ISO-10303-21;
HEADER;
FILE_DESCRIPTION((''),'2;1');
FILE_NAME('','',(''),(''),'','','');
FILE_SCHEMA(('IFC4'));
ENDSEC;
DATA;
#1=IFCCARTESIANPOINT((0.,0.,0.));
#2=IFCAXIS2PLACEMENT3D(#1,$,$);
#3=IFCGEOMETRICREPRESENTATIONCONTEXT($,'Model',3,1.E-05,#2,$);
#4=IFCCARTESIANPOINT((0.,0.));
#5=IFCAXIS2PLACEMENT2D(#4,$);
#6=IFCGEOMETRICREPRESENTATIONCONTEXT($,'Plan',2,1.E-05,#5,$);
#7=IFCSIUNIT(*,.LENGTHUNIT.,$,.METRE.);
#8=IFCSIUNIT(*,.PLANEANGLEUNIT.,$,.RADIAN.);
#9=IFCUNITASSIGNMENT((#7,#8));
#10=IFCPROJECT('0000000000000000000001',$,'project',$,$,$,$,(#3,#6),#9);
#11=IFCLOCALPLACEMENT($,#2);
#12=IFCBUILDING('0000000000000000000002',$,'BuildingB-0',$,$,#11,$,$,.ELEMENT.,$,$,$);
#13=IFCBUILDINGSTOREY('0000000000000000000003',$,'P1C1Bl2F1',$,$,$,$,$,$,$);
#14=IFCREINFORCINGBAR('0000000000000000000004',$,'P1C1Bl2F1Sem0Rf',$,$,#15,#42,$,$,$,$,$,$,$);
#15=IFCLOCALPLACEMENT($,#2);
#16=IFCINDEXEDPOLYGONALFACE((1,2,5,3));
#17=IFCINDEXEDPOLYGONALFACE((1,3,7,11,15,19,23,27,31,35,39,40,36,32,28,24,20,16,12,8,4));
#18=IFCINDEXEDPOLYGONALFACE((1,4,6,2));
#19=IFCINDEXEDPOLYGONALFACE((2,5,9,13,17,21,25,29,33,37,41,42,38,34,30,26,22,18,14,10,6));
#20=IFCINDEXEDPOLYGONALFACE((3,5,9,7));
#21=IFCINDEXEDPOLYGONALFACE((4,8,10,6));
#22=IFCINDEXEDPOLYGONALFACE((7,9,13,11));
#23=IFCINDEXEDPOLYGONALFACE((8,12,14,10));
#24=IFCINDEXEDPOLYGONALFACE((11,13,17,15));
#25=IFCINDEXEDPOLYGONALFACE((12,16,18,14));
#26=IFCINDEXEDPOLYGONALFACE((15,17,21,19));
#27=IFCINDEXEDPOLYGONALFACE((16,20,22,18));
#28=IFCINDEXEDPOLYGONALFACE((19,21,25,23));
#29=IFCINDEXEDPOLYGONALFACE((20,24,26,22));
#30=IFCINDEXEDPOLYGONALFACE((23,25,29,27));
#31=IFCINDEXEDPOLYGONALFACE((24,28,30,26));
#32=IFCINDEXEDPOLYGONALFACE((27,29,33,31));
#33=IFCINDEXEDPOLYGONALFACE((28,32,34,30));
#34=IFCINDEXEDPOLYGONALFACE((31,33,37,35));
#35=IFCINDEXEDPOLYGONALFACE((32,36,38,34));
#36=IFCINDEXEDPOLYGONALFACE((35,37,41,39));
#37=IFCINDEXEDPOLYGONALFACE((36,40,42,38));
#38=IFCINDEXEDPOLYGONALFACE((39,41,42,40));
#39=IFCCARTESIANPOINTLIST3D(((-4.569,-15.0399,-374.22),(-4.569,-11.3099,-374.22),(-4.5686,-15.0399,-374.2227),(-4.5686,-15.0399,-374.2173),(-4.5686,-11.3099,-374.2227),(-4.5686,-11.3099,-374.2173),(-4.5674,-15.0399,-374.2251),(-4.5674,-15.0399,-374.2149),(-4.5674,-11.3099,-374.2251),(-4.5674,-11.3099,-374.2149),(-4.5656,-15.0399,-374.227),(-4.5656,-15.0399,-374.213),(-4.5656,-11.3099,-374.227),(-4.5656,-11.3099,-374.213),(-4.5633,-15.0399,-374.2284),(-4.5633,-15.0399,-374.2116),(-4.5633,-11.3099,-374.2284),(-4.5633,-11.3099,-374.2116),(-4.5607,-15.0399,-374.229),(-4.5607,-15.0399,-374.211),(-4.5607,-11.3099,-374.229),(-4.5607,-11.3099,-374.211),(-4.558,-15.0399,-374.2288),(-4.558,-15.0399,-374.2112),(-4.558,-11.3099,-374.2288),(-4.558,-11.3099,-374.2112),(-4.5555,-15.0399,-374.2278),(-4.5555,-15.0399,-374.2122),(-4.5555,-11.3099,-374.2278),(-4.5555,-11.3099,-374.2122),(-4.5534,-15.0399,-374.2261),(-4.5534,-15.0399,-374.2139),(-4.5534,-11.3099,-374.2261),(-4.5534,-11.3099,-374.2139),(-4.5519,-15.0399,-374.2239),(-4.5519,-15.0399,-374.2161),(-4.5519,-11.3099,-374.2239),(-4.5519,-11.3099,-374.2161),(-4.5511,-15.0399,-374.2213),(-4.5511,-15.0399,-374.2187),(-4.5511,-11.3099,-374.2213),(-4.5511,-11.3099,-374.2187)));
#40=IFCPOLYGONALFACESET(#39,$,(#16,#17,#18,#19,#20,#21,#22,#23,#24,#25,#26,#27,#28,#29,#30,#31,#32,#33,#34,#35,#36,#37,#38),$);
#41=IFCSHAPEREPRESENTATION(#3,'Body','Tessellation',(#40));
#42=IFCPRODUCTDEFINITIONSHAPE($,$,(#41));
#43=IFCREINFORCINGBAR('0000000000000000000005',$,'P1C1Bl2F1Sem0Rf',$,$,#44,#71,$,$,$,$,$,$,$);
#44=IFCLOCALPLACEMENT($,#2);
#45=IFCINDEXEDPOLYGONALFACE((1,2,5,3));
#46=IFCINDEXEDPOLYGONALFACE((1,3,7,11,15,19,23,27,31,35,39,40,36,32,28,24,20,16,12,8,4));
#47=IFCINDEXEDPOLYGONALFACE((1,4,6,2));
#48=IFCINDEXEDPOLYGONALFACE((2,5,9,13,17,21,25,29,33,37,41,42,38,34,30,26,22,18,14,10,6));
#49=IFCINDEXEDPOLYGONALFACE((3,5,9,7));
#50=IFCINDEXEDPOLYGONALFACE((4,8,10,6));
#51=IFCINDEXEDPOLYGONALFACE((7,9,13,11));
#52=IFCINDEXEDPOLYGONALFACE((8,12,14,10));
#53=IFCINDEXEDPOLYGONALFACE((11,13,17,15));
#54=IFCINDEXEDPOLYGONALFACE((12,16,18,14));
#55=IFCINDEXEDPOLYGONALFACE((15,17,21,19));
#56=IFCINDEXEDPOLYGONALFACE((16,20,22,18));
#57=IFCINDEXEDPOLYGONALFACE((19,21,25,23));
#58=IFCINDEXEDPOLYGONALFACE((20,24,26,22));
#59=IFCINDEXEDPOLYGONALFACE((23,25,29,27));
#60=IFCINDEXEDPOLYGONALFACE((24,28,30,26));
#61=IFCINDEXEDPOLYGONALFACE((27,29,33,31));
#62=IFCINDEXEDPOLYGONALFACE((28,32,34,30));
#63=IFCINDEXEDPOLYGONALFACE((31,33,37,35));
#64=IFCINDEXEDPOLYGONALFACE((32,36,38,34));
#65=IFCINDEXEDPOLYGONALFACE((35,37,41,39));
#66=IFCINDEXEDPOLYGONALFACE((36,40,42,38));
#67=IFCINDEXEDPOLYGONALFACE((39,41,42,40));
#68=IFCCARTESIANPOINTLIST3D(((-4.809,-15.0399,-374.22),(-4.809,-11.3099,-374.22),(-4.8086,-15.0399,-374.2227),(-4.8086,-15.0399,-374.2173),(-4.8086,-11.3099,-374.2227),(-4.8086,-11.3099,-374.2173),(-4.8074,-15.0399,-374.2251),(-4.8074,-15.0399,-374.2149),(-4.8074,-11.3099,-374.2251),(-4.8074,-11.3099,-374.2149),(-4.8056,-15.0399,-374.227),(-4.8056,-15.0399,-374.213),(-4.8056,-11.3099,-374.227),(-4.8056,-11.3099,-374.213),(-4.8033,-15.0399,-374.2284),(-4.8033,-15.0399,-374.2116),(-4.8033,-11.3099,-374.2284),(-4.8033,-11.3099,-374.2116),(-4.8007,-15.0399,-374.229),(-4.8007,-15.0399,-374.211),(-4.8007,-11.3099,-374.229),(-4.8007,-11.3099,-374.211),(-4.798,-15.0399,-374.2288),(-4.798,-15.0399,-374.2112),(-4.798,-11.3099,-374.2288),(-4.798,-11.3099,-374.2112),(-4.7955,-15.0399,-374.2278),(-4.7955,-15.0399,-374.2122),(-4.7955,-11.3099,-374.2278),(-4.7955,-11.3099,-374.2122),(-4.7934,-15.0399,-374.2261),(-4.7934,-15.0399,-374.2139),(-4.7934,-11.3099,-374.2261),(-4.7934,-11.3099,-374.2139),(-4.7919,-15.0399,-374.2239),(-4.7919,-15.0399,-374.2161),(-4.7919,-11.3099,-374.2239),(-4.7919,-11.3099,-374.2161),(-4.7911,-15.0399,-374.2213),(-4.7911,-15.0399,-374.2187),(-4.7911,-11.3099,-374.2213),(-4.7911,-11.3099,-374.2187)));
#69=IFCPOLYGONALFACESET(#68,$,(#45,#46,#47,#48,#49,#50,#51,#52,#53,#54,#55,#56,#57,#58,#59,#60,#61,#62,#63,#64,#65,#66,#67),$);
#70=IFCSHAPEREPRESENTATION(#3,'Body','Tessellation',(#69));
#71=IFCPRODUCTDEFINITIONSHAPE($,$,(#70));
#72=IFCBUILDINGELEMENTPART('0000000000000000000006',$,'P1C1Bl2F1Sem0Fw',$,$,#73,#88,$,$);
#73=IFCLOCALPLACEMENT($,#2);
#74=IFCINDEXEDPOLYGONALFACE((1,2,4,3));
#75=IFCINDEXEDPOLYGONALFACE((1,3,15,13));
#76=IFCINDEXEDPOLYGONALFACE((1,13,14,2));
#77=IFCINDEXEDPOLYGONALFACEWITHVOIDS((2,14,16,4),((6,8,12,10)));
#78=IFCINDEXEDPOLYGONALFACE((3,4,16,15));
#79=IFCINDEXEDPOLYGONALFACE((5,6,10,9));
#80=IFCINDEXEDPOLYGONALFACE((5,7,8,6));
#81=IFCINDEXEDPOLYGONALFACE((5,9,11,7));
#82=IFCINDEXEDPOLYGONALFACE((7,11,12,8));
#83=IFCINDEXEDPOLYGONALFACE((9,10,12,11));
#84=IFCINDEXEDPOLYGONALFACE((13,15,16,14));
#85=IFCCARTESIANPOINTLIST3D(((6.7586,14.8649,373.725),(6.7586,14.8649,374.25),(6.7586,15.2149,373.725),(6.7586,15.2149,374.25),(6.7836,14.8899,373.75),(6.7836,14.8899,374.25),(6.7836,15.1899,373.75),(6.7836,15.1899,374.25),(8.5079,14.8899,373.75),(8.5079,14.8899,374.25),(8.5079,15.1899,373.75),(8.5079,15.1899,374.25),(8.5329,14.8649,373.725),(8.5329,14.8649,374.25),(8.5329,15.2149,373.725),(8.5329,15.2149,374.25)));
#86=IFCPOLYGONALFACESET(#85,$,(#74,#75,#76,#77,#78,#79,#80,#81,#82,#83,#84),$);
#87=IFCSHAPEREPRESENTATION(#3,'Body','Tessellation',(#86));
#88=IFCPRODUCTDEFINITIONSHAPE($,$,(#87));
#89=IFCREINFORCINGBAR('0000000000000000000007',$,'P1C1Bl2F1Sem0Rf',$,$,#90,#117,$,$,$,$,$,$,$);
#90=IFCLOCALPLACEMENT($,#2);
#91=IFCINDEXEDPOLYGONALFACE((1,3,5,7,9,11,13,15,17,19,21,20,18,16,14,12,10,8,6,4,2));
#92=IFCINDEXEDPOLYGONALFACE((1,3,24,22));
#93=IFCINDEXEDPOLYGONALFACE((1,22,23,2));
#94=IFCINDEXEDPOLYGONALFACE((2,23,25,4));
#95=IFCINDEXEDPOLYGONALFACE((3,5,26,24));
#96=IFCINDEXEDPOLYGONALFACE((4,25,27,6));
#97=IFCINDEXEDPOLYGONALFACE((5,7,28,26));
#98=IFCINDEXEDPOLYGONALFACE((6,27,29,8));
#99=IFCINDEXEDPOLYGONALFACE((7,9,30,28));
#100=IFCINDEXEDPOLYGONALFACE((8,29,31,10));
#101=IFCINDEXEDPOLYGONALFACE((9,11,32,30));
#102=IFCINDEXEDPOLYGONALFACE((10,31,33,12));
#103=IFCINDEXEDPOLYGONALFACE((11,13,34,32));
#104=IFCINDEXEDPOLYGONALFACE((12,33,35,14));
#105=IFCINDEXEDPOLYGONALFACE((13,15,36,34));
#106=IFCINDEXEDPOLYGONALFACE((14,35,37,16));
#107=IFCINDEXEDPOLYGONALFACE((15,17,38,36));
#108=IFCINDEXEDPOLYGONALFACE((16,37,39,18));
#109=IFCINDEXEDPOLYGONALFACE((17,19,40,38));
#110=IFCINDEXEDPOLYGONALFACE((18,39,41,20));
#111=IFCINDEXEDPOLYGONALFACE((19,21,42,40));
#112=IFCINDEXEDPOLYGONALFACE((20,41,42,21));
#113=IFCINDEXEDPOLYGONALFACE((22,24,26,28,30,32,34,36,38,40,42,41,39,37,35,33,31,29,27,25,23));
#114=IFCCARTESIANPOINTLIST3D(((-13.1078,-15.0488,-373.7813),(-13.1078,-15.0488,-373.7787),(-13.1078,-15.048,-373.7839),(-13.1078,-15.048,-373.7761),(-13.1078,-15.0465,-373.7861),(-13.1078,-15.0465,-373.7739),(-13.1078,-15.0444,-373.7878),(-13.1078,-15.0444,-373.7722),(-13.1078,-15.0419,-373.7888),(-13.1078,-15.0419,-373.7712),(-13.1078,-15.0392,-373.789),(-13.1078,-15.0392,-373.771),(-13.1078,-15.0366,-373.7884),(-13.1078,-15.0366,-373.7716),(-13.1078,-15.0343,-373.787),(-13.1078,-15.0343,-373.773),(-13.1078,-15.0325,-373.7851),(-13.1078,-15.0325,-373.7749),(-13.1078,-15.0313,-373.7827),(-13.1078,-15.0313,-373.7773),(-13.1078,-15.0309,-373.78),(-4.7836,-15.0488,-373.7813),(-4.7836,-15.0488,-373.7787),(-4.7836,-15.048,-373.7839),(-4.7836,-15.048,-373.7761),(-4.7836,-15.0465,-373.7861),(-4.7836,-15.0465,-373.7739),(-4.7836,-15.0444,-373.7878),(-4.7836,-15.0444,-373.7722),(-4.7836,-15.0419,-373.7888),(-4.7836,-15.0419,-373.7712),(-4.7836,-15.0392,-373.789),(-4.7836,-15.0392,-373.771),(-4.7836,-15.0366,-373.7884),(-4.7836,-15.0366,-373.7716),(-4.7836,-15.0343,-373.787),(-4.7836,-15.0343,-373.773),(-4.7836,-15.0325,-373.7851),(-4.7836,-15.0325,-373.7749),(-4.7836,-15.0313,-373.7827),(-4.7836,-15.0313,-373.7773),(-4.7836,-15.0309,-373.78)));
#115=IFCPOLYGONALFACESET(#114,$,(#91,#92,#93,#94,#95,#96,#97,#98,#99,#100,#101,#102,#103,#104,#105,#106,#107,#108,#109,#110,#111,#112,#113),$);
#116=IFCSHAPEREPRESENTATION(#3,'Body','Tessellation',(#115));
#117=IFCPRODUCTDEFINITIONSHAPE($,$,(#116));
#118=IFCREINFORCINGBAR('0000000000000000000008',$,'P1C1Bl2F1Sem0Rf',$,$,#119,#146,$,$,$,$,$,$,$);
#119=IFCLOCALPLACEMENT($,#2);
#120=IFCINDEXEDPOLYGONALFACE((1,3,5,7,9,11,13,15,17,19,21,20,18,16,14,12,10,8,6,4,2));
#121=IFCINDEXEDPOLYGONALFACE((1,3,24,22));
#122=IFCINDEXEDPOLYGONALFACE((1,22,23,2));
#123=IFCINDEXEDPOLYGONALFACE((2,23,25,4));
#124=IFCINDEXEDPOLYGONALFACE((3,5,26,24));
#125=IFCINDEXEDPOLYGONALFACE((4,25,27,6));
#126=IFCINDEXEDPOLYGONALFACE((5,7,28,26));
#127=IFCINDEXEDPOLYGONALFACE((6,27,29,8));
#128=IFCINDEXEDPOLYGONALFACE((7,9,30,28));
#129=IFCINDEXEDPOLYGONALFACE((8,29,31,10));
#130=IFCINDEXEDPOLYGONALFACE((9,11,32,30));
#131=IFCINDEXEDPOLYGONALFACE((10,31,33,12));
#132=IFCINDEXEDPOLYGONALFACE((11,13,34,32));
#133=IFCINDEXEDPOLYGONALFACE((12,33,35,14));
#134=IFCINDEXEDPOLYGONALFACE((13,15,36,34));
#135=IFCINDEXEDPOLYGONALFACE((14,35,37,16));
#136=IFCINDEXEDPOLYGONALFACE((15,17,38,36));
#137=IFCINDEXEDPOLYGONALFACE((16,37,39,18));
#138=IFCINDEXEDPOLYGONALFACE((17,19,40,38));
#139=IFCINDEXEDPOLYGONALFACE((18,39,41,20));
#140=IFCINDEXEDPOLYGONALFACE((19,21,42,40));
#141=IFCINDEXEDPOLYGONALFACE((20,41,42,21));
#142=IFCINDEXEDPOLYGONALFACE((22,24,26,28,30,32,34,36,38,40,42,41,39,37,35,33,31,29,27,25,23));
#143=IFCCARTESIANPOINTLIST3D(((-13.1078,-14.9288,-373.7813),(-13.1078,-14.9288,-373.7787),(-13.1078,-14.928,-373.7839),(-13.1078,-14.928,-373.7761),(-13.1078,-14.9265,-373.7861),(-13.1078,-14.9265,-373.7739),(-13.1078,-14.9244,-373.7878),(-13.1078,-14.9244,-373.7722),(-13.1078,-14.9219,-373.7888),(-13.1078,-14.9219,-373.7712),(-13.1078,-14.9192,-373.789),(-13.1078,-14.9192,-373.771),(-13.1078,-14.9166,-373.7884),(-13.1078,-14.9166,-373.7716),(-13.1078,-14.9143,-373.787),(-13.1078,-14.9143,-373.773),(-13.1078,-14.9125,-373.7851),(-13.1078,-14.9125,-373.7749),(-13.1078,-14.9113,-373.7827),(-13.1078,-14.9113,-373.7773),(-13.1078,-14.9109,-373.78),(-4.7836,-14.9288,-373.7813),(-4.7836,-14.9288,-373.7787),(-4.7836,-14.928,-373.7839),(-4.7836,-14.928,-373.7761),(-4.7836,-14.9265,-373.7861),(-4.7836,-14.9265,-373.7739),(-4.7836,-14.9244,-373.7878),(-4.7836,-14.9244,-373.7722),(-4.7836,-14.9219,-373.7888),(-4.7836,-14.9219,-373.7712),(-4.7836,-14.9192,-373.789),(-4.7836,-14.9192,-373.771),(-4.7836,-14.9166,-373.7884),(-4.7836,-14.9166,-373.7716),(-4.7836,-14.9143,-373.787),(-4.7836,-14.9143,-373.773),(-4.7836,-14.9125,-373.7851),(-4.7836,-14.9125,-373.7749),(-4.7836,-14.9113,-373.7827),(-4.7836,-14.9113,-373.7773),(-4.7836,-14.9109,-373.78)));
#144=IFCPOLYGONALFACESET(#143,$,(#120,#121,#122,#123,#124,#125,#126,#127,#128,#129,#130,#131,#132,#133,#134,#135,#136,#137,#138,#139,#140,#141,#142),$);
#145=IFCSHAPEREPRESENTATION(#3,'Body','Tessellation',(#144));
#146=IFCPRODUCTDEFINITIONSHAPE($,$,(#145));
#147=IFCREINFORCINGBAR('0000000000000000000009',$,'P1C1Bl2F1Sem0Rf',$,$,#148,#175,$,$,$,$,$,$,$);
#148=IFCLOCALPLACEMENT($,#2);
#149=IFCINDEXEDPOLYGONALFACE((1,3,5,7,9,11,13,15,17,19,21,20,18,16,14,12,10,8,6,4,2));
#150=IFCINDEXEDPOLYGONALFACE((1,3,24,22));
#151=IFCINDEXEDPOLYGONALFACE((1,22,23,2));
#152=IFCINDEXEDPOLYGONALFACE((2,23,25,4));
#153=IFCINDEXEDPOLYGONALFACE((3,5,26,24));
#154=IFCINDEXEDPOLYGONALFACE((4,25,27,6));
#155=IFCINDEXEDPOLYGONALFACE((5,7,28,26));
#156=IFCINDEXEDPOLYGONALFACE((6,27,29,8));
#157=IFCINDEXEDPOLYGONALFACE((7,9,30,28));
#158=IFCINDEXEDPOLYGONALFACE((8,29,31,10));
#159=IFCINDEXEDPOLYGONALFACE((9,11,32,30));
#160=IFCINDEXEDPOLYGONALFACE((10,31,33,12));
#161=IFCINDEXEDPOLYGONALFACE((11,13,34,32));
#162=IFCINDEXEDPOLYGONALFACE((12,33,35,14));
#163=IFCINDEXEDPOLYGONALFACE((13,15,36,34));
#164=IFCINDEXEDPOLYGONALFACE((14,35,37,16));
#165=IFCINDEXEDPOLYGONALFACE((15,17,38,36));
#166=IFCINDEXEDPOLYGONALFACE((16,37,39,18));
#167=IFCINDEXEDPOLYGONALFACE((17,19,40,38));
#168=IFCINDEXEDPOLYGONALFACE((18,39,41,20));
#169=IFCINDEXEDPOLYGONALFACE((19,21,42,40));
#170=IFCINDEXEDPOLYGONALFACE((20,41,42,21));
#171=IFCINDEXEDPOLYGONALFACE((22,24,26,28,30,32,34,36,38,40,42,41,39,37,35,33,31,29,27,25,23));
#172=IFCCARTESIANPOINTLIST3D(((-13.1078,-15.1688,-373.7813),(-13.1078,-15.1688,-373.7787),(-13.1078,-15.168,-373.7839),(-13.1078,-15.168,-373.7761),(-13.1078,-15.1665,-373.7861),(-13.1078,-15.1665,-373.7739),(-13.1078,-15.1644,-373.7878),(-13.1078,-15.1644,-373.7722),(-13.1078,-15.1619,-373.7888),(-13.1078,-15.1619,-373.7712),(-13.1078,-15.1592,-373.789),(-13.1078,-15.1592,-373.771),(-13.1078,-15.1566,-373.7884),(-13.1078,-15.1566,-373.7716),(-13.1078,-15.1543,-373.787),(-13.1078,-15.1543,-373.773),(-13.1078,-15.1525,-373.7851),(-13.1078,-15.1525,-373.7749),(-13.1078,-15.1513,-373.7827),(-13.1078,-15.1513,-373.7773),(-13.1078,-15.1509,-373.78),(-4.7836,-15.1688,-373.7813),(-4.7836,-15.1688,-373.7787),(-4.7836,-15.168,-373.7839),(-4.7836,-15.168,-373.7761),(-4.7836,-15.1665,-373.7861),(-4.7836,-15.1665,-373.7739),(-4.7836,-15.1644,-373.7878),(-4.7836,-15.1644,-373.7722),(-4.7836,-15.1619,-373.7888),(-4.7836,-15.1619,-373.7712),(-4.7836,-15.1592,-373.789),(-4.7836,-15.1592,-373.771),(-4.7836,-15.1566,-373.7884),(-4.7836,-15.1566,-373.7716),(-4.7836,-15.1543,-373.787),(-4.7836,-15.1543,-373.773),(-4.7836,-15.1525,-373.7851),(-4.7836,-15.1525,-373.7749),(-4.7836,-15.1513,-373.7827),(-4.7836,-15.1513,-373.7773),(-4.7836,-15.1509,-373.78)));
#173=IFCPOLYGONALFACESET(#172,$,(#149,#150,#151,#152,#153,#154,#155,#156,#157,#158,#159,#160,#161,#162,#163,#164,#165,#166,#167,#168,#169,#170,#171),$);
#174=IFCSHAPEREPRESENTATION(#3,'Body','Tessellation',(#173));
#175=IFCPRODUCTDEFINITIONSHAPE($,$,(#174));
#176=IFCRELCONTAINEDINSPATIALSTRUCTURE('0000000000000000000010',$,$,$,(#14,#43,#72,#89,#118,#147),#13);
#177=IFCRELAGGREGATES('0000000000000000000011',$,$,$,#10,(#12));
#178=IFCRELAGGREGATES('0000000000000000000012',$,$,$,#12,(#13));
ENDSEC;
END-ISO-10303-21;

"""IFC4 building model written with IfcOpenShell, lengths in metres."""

from ifc_helpers import new_model, entity, si_unit, origin, origin_2d, place, context, project, spatial, polyline, outline, extrude, element, save


model = new_model("IFC4")

# Units and contexts
model_context = context("Model", 3, precision=1e-05, world=origin())
plan_context = context("Plan", 2, precision=1e-05, world=origin_2d())
ifc_project = project(units=[si_unit("LENGTHUNIT", "METRE"), si_unit("PLANEANGLEUNIT", "RADIAN")], contexts=[model_context, plan_context])

# Building, storey
building_placement = place(None, origin())
building = spatial("IfcBuilding", under=ifc_project, at=building_placement, Name="BuildingB-0", CompositionType="ELEMENT")
storey = spatial("IfcBuildingStorey", under=building, Name="P1C1Bl2F1")

# Reinforcing bars
element("IfcReinforcingBar", 1, inside=storey, Name="P1C1Bl2F1Sem0Rf", context=model_context, shape_type="SweptSolid", body=[
    entity("IfcSurfaceCurveSweptAreaSolid", entity("IfcCircleProfileDef", "AREA", None, None, 0.009), None, entity("IfcPolyline", [entity("IfcCartesianPoint", [4.56, 15.0399, 374.22]), entity("IfcCartesianPoint", [4.56, 11.3099, 374.22])]), None, None, entity("IfcPlane", entity("IfcAxis2Placement3D", entity("IfcCartesianPoint", [4.56, 15.0399, 374.22]), entity("IfcDirection", [0.0, 0.0, 1.0]), entity("IfcDirection", [1.0, 0.0, 0.0])))),
])
element("IfcReinforcingBar", 2, inside=storey, Name="P1C1Bl2F1Sem0Rf", context=model_context, shape_type="SweptSolid", body=[
    entity("IfcSurfaceCurveSweptAreaSolid", entity("IfcCircleProfileDef", "AREA", None, None, 0.009), None, entity("IfcPolyline", [entity("IfcCartesianPoint", [4.8, 15.0399, 374.22]), entity("IfcCartesianPoint", [4.8, 11.3099, 374.22])]), None, None, entity("IfcPlane", entity("IfcAxis2Placement3D", entity("IfcCartesianPoint", [4.8, 15.0399, 374.22]), entity("IfcDirection", [0.0, 0.0, 1.0]), entity("IfcDirection", [1.0, 0.0, 0.0])))),
])

# Building element part, opening
building_element_part_1 = element("IfcBuildingElementPart", 3, inside=storey, Name="P1C1Bl2F1Sem0Fw", context=model_context, shape_type="SweptSolid", body=[
    extrude(outline(polyline([(6.7586, 14.8649, 373.725), (6.7586, 15.2149, 373.725), (8.5329, 15.2149, 373.725), (8.5329, 14.8649, 373.725), (6.7586, 14.8649, 373.725)])), None, (0.0, 0.0, 1.0), 0.525),
])
element("IfcOpeningElement", 4, inside=storey, cuts=building_element_part_1, context=model_context, shape_type="SweptSolid", body=[
    extrude(outline(polyline([(6.7836, 14.8899, 373.75), (6.7836, 15.1899, 373.75), (8.5079, 15.1899, 373.75), (8.5079, 14.8899, 373.75), (6.7836, 14.8899, 373.75)])), None, (0.0, 0.0, 1.0), 0.5),
])

# Reinforcing bars
element("IfcReinforcingBar", 5, inside=storey, Name="P1C1Bl2F1Sem0Rf", context=model_context, shape_type="SweptSolid", body=[
    entity("IfcSurfaceCurveSweptAreaSolid", entity("IfcCircleProfileDef", "AREA", None, None, 0.009), None, entity("IfcPolyline", [entity("IfcCartesianPoint", [4.7836, 15.0399, 373.78]), entity("IfcCartesianPoint", [13.1078, 15.0399, 373.78])]), None, None, entity("IfcPlane", entity("IfcAxis2Placement3D", entity("IfcCartesianPoint", [4.7836, 15.0399, 373.78]), entity("IfcDirection", [0.0, 0.0, 1.0]), entity("IfcDirection", [1.0, 0.0, 0.0])))),
])
element("IfcReinforcingBar", 6, inside=storey, Name="P1C1Bl2F1Sem0Rf", context=model_context, shape_type="SweptSolid", body=[
    entity("IfcSurfaceCurveSweptAreaSolid", entity("IfcCircleProfileDef", "AREA", None, None, 0.009), None, entity("IfcPolyline", [entity("IfcCartesianPoint", [4.7836, 14.9199, 373.78]), entity("IfcCartesianPoint", [13.1078, 14.9199, 373.78])]), None, None, entity("IfcPlane", entity("IfcAxis2Placement3D", entity("IfcCartesianPoint", [4.7836, 14.9199, 373.78]), entity("IfcDirection", [0.0, 0.0, 1.0]), entity("IfcDirection", [1.0, 0.0, 0.0])))),
])
element("IfcReinforcingBar", 7, inside=storey, Name="P1C1Bl2F1Sem0Rf", context=model_context, shape_type="SweptSolid", body=[
    entity("IfcSurfaceCurveSweptAreaSolid", entity("IfcCircleProfileDef", "AREA", None, None, 0.009), None, entity("IfcPolyline", [entity("IfcCartesianPoint", [4.7836, 15.1599, 373.78]), entity("IfcCartesianPoint", [13.1078, 15.1599, 373.78])]), None, None, entity("IfcPlane", entity("IfcAxis2Placement3D", entity("IfcCartesianPoint", [4.7836, 15.1599, 373.78]), entity("IfcDirection", [0.0, 0.0, 1.0]), entity("IfcDirection", [1.0, 0.0, 0.0])))),
])

save(model, "model.ifc")
